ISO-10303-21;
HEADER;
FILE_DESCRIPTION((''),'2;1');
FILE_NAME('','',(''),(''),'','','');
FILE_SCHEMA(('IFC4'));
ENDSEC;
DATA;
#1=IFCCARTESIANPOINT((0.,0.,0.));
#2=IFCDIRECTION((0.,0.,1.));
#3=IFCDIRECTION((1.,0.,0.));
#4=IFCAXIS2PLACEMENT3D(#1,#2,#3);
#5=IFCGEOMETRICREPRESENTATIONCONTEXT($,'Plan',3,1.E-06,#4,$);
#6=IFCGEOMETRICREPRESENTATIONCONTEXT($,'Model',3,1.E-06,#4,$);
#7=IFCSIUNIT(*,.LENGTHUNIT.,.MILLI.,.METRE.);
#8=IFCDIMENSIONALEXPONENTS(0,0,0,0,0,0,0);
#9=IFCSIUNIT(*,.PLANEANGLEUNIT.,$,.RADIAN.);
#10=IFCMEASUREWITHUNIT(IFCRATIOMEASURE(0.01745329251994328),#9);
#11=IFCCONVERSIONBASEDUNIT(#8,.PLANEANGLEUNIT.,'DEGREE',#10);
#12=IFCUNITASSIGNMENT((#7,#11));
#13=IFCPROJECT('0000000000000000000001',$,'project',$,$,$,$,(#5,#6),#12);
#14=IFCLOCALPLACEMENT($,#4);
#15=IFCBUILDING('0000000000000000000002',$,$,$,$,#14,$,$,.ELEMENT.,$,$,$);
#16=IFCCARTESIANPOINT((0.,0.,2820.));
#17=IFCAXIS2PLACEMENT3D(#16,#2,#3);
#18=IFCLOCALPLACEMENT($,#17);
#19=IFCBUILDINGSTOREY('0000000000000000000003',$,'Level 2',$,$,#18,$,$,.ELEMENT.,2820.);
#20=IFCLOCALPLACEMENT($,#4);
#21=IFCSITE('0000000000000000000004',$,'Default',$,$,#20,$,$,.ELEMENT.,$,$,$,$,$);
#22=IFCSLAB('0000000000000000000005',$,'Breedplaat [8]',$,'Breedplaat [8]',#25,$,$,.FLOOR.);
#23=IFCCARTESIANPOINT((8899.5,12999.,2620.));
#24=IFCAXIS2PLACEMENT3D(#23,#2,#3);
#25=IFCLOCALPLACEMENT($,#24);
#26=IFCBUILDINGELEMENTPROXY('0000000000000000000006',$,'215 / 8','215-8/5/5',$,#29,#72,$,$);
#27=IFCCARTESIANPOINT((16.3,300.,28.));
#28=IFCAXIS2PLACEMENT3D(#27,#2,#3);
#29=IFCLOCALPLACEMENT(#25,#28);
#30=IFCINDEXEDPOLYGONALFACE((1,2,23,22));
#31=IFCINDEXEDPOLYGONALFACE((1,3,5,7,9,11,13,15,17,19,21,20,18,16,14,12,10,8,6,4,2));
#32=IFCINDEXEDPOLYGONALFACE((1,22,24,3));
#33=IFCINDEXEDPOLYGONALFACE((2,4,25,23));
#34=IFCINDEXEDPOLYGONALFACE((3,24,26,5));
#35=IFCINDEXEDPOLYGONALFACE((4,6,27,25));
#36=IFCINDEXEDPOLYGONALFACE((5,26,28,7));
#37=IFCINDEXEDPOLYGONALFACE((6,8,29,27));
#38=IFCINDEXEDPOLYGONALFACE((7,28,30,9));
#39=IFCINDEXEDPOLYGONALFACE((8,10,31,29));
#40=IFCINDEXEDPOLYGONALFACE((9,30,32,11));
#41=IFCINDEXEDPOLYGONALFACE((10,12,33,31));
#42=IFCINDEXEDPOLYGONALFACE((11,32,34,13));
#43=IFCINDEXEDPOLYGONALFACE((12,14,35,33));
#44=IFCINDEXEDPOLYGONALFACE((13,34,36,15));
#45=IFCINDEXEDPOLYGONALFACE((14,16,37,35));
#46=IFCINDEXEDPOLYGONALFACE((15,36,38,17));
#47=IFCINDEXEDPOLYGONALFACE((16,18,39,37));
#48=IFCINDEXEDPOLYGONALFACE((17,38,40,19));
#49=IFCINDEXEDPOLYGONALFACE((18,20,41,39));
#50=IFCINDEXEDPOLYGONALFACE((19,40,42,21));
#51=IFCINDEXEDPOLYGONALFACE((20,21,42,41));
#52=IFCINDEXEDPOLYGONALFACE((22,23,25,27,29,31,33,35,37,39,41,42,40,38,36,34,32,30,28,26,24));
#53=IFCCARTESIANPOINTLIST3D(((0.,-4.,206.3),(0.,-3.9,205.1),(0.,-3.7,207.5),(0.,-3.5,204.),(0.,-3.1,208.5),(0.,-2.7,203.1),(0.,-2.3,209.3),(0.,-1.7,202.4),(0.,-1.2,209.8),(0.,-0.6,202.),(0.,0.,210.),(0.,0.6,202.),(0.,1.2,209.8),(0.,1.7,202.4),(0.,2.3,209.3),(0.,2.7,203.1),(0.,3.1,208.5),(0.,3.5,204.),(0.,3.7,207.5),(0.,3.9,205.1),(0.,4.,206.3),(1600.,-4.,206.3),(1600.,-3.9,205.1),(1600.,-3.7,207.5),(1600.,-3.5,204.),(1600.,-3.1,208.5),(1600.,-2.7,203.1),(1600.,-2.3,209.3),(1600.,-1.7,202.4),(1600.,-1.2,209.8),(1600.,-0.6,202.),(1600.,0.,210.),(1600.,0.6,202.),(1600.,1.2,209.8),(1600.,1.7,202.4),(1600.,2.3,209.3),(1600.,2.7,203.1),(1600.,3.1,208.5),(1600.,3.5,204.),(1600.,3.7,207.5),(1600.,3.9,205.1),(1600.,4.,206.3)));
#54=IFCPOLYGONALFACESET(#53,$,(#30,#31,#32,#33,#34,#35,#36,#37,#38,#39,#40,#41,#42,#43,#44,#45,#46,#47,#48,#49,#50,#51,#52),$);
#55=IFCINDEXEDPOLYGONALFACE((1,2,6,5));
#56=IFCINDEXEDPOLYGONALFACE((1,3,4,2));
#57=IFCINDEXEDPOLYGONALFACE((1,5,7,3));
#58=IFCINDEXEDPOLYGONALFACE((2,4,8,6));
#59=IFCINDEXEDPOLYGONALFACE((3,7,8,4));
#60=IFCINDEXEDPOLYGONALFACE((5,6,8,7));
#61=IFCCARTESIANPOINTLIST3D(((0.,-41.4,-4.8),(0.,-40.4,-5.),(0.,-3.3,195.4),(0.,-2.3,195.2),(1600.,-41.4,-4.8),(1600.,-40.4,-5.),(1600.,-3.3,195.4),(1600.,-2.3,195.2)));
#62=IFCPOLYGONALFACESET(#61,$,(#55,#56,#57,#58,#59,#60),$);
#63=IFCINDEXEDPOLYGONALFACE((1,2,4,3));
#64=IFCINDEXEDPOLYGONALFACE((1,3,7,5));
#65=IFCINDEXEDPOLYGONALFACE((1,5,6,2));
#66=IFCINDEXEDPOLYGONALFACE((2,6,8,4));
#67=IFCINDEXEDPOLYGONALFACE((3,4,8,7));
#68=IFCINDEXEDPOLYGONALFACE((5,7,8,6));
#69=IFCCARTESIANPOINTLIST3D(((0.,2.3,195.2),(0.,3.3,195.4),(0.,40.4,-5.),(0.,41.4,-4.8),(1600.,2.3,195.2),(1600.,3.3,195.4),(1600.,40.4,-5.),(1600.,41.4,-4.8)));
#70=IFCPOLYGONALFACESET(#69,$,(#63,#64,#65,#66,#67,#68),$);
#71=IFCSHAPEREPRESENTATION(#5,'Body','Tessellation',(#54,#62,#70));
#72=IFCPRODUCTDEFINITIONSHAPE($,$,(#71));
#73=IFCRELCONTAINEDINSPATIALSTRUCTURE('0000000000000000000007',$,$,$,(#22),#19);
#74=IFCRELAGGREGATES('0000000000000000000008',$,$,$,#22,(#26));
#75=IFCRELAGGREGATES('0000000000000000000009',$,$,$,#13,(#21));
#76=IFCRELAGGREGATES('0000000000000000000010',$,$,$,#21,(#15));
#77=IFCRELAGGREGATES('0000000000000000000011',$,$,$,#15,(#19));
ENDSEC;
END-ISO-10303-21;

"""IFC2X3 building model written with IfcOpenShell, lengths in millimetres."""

from ifc_helpers import new_model, entity, si_unit, converted_unit, frame, origin_with_axes, origin_2d_with_axis, place, context, project, spatial, rectangle, circle, extrude, element, aggregate, save


model = new_model("IFC2X3")

# Units and contexts
plan_context = context("Plan", 3, precision=1e-06, world=origin_with_axes())
model_context = context("Model", 3, precision=1e-06, world=origin_with_axes())
ifc_project = project(units=[si_unit("LENGTHUNIT", "METRE", prefix="MILLI"), converted_unit("PLANEANGLEUNIT", "DEGREE", entity("IfcRatioMeasure", 0.01745329251994328), si_unit("PLANEANGLEUNIT", "RADIAN"), dimensions=[0, 0, 0, 0, 0, 0, 0])], contexts=[plan_context, model_context])

# Site, building, storey
site_placement = place(None, origin_with_axes())
site = spatial("IfcSite", under=ifc_project, at=site_placement, Name="Default", CompositionType="ELEMENT")
building_placement = place(None, origin_with_axes())
building = spatial("IfcBuilding", under=site, at=building_placement, CompositionType="ELEMENT")
storey_placement = place(None, frame((0.0, 0.0, 2820.0), z_axis=(0.0, 0.0, 1.0), x_axis=(1.0, 0.0, 0.0)))
storey = spatial("IfcBuildingStorey", under=building, at=storey_placement, Name="Level 2", CompositionType="ELEMENT", Elevation=2820.0)

# Slab, building element proxy
slab_1_placement = place(None, frame((8899.5, 12999.0, 2620.0), z_axis=(0.0, 0.0, 1.0), x_axis=(1.0, 0.0, 0.0)))
slab_1 = element("IfcSlab", 1, at=slab_1_placement, inside=storey, Name="Breedplaat [8]", ObjectType="Breedplaat [8]", PredefinedType="FLOOR")
proxy_1_placement = place(slab_1_placement, frame((16.3, 300.0, 28.0), z_axis=(0.0, 0.0, 1.0), x_axis=(1.0, 0.0, 0.0)))
proxy_1 = element("IfcBuildingElementProxy", 2, at=proxy_1_placement, Name="215 / 8", Description="215-8/5/5", context=plan_context, shape_type="SweptSolid", body=[
    extrude(circle(Radius=4.0, at=origin_2d_with_axis()), frame((0.0, 0.0, 206.0), z_axis=(1.0, 0.0, 0.0), x_axis=(0.0, 0.0, 1.0)), (0.0, 0.0, 1.0), 1600.0),
    extrude(rectangle(XDim=203.8, YDim=1.0, at=origin_2d_with_axis()), frame((0.0, -21.9, 95.2), z_axis=(1.0, 0.0, 0.0), x_axis=(0.0, 0.187112, 0.982339)), (0.0, 0.0, 1.0), 1600.0),
    extrude(rectangle(XDim=203.8, YDim=1.0, at=origin_2d_with_axis()), frame((0.0, 21.9, 95.2), z_axis=(1.0, 0.0, 0.0), x_axis=(0.0, -0.187112, 0.982339)), (0.0, 0.0, 1.0), 1600.0),
])
aggregate(slab_1, [proxy_1])

save(model, "model.ifc")
